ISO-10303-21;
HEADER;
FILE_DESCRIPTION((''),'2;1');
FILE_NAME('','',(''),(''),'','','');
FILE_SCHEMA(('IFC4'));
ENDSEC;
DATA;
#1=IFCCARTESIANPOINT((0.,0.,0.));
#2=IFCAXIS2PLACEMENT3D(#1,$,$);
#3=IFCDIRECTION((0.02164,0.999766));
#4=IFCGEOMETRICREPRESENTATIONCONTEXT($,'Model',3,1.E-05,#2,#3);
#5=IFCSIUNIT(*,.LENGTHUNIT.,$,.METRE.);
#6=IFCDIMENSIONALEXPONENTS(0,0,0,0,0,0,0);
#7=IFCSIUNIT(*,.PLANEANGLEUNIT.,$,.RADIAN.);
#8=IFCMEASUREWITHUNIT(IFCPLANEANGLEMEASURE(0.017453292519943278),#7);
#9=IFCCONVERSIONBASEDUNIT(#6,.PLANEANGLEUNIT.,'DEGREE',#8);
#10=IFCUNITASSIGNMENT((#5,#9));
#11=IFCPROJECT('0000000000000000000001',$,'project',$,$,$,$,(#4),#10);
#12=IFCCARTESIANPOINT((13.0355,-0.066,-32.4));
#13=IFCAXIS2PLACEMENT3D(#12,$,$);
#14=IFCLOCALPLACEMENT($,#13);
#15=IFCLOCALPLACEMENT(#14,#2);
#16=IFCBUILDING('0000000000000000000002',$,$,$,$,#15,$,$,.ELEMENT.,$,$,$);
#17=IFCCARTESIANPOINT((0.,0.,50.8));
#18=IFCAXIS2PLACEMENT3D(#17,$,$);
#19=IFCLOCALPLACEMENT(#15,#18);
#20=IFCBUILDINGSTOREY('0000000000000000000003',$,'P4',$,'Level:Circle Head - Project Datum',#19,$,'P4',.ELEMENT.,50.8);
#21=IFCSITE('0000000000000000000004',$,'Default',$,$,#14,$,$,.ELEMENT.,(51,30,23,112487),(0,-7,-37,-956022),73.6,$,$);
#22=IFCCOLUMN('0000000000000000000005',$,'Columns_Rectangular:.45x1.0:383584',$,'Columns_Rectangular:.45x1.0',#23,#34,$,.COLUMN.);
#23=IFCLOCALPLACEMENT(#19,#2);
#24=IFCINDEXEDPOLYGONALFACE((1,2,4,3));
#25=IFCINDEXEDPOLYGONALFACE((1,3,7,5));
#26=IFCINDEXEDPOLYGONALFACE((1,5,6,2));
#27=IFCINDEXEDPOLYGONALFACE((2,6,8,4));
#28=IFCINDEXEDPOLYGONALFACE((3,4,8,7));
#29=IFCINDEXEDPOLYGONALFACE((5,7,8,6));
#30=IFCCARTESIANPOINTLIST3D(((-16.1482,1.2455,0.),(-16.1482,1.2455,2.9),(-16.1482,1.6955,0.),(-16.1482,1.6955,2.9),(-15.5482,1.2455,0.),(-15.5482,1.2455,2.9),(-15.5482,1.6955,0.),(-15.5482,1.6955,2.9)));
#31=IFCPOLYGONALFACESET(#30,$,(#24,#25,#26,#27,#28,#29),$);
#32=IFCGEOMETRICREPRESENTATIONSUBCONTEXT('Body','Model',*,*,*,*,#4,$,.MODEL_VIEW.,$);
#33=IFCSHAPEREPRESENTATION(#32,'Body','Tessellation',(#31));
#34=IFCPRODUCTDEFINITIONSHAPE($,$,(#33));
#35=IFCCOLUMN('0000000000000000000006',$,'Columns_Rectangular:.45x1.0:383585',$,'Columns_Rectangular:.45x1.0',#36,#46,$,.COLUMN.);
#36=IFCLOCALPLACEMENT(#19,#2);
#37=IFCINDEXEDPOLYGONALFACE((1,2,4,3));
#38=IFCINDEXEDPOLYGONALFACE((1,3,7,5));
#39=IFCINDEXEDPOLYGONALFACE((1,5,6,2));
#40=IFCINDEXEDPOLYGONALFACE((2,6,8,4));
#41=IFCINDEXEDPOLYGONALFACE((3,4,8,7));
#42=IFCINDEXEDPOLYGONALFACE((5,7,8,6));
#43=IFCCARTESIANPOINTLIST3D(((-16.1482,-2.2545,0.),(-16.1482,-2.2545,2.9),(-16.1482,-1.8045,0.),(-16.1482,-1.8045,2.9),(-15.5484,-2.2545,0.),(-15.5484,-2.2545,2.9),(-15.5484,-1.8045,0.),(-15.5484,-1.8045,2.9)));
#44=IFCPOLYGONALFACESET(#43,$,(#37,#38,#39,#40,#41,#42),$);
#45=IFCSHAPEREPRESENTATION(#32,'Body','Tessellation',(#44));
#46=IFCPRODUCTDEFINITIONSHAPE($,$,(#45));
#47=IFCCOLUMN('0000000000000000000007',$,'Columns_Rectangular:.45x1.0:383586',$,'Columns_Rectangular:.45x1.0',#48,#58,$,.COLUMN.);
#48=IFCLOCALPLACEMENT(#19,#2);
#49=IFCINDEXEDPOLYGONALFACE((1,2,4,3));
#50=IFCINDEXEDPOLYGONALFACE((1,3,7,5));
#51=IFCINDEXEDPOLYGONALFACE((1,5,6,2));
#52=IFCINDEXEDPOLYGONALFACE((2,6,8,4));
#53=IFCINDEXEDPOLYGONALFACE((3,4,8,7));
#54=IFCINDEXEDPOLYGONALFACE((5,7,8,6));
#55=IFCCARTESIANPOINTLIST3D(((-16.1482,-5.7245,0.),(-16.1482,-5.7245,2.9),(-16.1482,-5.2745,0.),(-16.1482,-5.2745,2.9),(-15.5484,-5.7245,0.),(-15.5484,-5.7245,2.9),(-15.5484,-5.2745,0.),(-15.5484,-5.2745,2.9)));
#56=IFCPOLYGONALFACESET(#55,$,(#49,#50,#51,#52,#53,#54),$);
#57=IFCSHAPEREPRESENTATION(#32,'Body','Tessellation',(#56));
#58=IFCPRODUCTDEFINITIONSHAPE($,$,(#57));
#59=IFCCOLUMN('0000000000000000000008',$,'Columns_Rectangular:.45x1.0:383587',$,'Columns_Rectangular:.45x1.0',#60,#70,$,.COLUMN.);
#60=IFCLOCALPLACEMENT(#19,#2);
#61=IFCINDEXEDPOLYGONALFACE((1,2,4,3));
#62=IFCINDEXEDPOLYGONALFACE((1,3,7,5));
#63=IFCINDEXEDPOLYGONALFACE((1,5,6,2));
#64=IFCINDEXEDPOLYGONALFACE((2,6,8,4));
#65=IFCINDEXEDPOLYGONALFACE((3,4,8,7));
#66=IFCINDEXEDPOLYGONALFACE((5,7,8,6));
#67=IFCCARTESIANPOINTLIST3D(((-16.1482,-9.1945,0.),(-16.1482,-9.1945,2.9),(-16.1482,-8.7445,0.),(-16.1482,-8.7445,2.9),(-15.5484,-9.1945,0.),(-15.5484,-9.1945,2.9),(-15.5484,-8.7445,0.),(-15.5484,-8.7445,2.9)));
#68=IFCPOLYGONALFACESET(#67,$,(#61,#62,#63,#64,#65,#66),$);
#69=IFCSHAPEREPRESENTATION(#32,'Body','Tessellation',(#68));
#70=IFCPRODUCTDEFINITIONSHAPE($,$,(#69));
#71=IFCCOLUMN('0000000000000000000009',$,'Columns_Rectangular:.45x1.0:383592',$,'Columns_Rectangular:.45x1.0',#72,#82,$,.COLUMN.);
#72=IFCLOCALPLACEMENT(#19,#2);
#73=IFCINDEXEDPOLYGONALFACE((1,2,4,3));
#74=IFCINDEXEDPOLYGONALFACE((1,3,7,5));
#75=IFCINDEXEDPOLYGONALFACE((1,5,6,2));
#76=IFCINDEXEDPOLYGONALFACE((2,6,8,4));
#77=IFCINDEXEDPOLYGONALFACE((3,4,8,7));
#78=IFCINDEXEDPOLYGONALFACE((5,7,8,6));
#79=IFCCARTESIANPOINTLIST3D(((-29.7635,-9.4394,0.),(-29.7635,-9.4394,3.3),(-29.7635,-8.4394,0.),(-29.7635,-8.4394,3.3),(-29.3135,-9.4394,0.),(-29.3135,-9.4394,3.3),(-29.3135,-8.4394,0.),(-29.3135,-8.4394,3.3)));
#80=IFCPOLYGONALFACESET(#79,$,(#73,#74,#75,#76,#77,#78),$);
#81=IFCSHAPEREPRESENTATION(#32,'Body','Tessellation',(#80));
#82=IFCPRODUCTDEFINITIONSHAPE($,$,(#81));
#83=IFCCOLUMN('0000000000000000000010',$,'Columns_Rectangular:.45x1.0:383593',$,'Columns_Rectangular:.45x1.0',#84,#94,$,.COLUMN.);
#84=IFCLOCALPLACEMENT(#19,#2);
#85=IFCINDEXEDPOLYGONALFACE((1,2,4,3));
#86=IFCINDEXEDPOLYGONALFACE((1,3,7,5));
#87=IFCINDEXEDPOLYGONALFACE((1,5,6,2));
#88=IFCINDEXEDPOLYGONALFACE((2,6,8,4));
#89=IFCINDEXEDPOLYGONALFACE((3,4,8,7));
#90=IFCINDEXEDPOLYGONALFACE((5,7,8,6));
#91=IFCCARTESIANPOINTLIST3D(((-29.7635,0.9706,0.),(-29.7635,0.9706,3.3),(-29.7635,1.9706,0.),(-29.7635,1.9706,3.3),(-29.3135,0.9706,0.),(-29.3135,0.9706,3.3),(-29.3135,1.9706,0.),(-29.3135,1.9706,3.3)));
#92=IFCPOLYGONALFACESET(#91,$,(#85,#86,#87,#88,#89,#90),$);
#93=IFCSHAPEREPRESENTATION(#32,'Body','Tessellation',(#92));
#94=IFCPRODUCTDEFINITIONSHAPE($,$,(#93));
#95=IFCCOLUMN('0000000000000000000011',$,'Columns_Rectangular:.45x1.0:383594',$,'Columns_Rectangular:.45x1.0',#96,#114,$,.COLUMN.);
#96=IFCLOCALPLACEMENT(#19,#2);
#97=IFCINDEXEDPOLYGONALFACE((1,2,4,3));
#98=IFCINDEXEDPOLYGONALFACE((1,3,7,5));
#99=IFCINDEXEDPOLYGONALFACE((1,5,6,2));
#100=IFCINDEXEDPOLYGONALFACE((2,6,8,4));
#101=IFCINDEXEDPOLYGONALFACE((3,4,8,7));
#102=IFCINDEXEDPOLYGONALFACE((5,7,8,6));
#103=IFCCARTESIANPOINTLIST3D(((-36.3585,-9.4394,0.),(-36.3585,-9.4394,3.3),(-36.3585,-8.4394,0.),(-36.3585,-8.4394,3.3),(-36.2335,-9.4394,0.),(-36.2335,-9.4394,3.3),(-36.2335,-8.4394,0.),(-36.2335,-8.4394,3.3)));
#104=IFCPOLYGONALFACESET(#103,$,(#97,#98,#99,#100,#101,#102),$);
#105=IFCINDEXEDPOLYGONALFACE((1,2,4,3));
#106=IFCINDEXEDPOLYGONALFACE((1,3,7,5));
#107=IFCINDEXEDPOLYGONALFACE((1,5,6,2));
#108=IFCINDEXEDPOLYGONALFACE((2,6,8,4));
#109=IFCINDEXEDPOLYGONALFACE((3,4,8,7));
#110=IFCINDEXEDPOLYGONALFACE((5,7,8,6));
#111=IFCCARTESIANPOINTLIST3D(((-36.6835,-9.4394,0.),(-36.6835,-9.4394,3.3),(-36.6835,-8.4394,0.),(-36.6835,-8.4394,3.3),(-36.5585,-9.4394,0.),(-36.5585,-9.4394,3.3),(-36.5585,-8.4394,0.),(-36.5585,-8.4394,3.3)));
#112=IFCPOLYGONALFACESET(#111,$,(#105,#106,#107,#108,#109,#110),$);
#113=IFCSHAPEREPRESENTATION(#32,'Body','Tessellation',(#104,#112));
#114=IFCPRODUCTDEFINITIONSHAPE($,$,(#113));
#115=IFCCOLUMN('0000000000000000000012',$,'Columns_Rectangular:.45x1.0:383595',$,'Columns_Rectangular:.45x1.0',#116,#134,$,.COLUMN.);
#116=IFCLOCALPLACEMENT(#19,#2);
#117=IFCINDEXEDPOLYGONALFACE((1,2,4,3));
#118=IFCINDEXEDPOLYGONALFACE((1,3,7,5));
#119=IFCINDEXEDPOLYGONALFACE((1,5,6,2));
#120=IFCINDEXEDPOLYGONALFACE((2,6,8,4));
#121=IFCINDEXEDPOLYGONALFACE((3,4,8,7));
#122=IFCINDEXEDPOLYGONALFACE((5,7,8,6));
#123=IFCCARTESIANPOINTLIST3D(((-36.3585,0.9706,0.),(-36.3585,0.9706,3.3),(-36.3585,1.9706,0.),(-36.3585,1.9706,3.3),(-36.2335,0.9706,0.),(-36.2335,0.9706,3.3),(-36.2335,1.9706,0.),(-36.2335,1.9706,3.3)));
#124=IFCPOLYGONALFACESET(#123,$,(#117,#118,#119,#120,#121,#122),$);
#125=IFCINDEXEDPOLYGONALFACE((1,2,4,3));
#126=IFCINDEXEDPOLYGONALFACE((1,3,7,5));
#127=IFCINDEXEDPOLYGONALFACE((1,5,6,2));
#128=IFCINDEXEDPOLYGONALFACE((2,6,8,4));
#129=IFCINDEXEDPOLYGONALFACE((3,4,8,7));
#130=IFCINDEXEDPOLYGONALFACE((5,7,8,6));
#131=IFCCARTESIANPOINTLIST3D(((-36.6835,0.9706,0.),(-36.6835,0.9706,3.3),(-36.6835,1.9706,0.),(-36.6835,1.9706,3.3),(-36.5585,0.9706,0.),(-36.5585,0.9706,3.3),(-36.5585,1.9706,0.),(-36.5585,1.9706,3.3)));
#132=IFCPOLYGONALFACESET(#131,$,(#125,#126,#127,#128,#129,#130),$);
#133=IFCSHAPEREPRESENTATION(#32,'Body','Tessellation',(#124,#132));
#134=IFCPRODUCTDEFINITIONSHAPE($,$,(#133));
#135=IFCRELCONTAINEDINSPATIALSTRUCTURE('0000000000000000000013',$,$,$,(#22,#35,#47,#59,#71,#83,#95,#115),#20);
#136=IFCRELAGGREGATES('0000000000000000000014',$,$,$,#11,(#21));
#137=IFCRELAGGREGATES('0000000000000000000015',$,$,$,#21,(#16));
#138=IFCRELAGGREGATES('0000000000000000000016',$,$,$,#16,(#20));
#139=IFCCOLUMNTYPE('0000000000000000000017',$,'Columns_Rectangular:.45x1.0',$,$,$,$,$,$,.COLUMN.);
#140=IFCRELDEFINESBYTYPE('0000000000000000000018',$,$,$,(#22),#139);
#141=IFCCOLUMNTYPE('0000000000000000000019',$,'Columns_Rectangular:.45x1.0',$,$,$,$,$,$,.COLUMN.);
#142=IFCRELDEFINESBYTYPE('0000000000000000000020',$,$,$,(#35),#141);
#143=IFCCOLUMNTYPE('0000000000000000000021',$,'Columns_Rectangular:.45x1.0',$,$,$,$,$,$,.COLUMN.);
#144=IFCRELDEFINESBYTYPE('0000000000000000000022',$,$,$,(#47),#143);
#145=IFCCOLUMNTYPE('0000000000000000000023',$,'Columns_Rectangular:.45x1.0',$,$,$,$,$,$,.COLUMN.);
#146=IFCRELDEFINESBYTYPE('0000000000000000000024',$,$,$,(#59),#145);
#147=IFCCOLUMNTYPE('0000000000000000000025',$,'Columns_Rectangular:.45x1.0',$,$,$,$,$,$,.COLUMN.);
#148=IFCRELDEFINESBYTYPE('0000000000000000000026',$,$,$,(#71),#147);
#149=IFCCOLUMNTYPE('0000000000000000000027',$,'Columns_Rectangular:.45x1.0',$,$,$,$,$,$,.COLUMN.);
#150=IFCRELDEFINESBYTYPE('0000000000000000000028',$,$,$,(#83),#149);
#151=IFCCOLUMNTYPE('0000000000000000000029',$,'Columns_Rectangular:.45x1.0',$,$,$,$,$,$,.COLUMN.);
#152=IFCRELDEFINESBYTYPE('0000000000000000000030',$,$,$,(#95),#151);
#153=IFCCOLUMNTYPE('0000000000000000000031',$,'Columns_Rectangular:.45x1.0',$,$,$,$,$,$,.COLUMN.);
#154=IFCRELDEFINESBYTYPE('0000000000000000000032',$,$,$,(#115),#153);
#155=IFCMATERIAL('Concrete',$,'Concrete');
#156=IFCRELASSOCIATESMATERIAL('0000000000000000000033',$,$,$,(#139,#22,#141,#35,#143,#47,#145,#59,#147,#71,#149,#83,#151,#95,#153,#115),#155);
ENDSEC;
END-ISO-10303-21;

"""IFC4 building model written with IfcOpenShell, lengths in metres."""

from ifc_helpers import new_model, entity, si_unit, converted_unit, direction, frame, origin, place, context, subcontext, project, spatial, indexed_curve, outline, extrude, source, transform, mapped, material, type_object, type_shapes, element, save


model = new_model("IFC4")

# Units and contexts
model_context = context("Model", 3, precision=1e-05, world=origin(), true_north=direction((0.02164, 0.999766)))
body_context = subcontext(model_context, "Body", "Model", "MODEL_VIEW")
ifc_project = project(units=[si_unit("LENGTHUNIT", "METRE"), converted_unit("PLANEANGLEUNIT", "DEGREE", entity("IfcPlaneAngleMeasure", 0.017453292519943278), si_unit("PLANEANGLEUNIT", "RADIAN"), dimensions=[0, 0, 0, 0, 0, 0, 0])], contexts=[model_context])

# Site, building, storey
site_placement = place(None, frame((13.0355, -0.066, -32.4)))
site = spatial("IfcSite", under=ifc_project, at=site_placement, Name="Default", CompositionType="ELEMENT", RefLatitude=(51, 30, 23, 112487), RefLongitude=(0, -7, -37, -956022), RefElevation=73.6)
building_placement = place(site_placement, origin())
building = spatial("IfcBuilding", under=site, at=building_placement, CompositionType="ELEMENT")
storey_placement = place(building_placement, frame((0.0, 0.0, 50.8)))
storey = spatial("IfcBuildingStorey", under=building, at=storey_placement, Name="P4", ObjectType="Level:Circle Head - Project Datum", LongName="P4", CompositionType="ELEMENT", Elevation=50.8)

# Columns
ifc_material = material(Name="Concrete", Category="Concrete")
column_type_1 = type_object("IfcColumnType", Name="Columns_Rectangular:.45x1.0", PredefinedType="COLUMN", material=ifc_material)
shared_shape_1 = source(origin(), body_context, "Body", "SweptSolid", [
    extrude(outline(indexed_curve([(-0.3, -0.225), (0.3, -0.225), (0.3, 0.225), (-0.3, 0.225), (-0.3, -0.225)], self_intersect=False)), frame((-15.8482, 1.4705, 50.8), z_axis=(0.0, 0.0, 1.0), x_axis=(-1.0, 0.0, 0.0)), (0.0, 0.0, 1.0), 2.9),
])
type_shapes(column_type_1, [shared_shape_1])
column_1_placement = place(storey_placement, frame((0.0, 0.0, -50.8)))
element("IfcColumn", 1, at=column_1_placement, inside=storey, type_object=column_type_1, material=ifc_material, Name="Columns_Rectangular:.45x1.0:383584", ObjectType="Columns_Rectangular:.45x1.0", PredefinedType="COLUMN", context=body_context, shape_type="MappedRepresentation", body=[
    mapped(shared_shape_1, transform((0.0, 0.0, 0.0), scale=1.0)),
])
column_type_2 = type_object("IfcColumnType", Name="Columns_Rectangular:.45x1.0", PredefinedType="COLUMN", material=ifc_material)
shared_shape_2 = source(origin(), body_context, "Body", "SweptSolid", [
    extrude(outline(indexed_curve([(-0.2999, -0.225), (0.2999, -0.225), (0.2999, 0.225), (-0.2999, 0.225), (-0.2999, -0.225)], self_intersect=False)), frame((-15.8483, -2.0295, 50.8), z_axis=(0.0, 0.0, 1.0), x_axis=(-1.0, 0.0, 0.0)), (0.0, 0.0, 1.0), 2.9),
])
type_shapes(column_type_2, [shared_shape_2])
column_2_placement = place(storey_placement, frame((0.0, 0.0, -50.8)))
element("IfcColumn", 2, at=column_2_placement, inside=storey, type_object=column_type_2, material=ifc_material, Name="Columns_Rectangular:.45x1.0:383585", ObjectType="Columns_Rectangular:.45x1.0", PredefinedType="COLUMN", context=body_context, shape_type="MappedRepresentation", body=[
    mapped(shared_shape_2, transform((0.0, 0.0, 0.0), scale=1.0)),
])
column_type_3 = type_object("IfcColumnType", Name="Columns_Rectangular:.45x1.0", PredefinedType="COLUMN", material=ifc_material)
shared_shape_3 = source(origin(), body_context, "Body", "SweptSolid", [
    extrude(outline(indexed_curve([(-0.2999, -0.225), (0.2999, -0.225), (0.2999, 0.225), (-0.2999, 0.225), (-0.2999, -0.225)], self_intersect=False)), frame((-15.8483, -5.4995, 50.8), z_axis=(0.0, 0.0, 1.0), x_axis=(-1.0, 0.0, 0.0)), (0.0, 0.0, 1.0), 2.9),
])
type_shapes(column_type_3, [shared_shape_3])
column_3_placement = place(storey_placement, frame((0.0, 0.0, -50.8)))
element("IfcColumn", 3, at=column_3_placement, inside=storey, type_object=column_type_3, material=ifc_material, Name="Columns_Rectangular:.45x1.0:383586", ObjectType="Columns_Rectangular:.45x1.0", PredefinedType="COLUMN", context=body_context, shape_type="MappedRepresentation", body=[
    mapped(shared_shape_3, transform((0.0, 0.0, 0.0), scale=1.0)),
])
column_type_4 = type_object("IfcColumnType", Name="Columns_Rectangular:.45x1.0", PredefinedType="COLUMN", material=ifc_material)
shared_shape_4 = source(origin(), body_context, "Body", "SweptSolid", [
    extrude(outline(indexed_curve([(-0.2999, -0.225), (0.2999, -0.225), (0.2999, 0.225), (-0.2999, 0.225), (-0.2999, -0.225)], self_intersect=False)), frame((-15.8483, -8.9695, 50.8), z_axis=(0.0, 0.0, 1.0), x_axis=(-1.0, 0.0, 0.0)), (0.0, 0.0, 1.0), 2.9),
])
type_shapes(column_type_4, [shared_shape_4])
column_4_placement = place(storey_placement, frame((0.0, 0.0, -50.8)))
element("IfcColumn", 4, at=column_4_placement, inside=storey, type_object=column_type_4, material=ifc_material, Name="Columns_Rectangular:.45x1.0:383587", ObjectType="Columns_Rectangular:.45x1.0", PredefinedType="COLUMN", context=body_context, shape_type="MappedRepresentation", body=[
    mapped(shared_shape_4, transform((0.0, 0.0, 0.0), scale=1.0)),
])
column_type_5 = type_object("IfcColumnType", Name="Columns_Rectangular:.45x1.0", PredefinedType="COLUMN", material=ifc_material)
shared_shape_5 = source(origin(), body_context, "Body", "SweptSolid", [
    extrude(outline(indexed_curve([(-0.5, -0.225), (0.5, -0.225), (0.5, 0.225), (-0.5, 0.225), (-0.5, -0.225)], self_intersect=False)), frame((-29.5385, -8.9394, 50.8), z_axis=(0.0, 0.0, 1.0), x_axis=(0.0, 1.0, 0.0)), (0.0, 0.0, 1.0), 3.3),
])
type_shapes(column_type_5, [shared_shape_5])
column_5_placement = place(storey_placement, frame((0.0, 0.0, -50.8)))
element("IfcColumn", 5, at=column_5_placement, inside=storey, type_object=column_type_5, material=ifc_material, Name="Columns_Rectangular:.45x1.0:383592", ObjectType="Columns_Rectangular:.45x1.0", PredefinedType="COLUMN", context=body_context, shape_type="MappedRepresentation", body=[
    mapped(shared_shape_5, transform((0.0, 0.0, 0.0), scale=1.0)),
])
column_type_6 = type_object("IfcColumnType", Name="Columns_Rectangular:.45x1.0", PredefinedType="COLUMN", material=ifc_material)
shared_shape_6 = source(origin(), body_context, "Body", "SweptSolid", [
    extrude(outline(indexed_curve([(-0.5, -0.225), (0.5, -0.225), (0.5, 0.225), (-0.5, 0.225), (-0.5, -0.225)], self_intersect=False)), frame((-29.5385, 1.4706, 50.8), z_axis=(0.0, 0.0, 1.0), x_axis=(0.0, 1.0, 0.0)), (0.0, 0.0, 1.0), 3.3),
])
type_shapes(column_type_6, [shared_shape_6])
column_6_placement = place(storey_placement, frame((0.0, 0.0, -50.8)))
element("IfcColumn", 6, at=column_6_placement, inside=storey, type_object=column_type_6, material=ifc_material, Name="Columns_Rectangular:.45x1.0:383593", ObjectType="Columns_Rectangular:.45x1.0", PredefinedType="COLUMN", context=body_context, shape_type="MappedRepresentation", body=[
    mapped(shared_shape_6, transform((0.0, 0.0, 0.0), scale=1.0)),
])
column_type_7 = type_object("IfcColumnType", Name="Columns_Rectangular:.45x1.0", PredefinedType="COLUMN", material=ifc_material)
shared_shape_7 = source(origin(), body_context, "Body", "SweptSolid", [
    extrude(outline(indexed_curve([(-0.0625, -0.5), (0.0625, -0.5), (0.0625, 0.5), (-0.0625, 0.5), (-0.0625, -0.5)], self_intersect=False)), frame((-36.296, -8.9394, 50.8), z_axis=(0.0, 0.0, 1.0), x_axis=(-1.0, 0.0, 0.0)), (0.0, 0.0, 1.0), 3.3),
    extrude(outline(indexed_curve([(-0.0625, -0.5), (0.0625, -0.5), (0.0625, 0.5), (-0.0625, 0.5), (-0.0625, -0.5)], self_intersect=False)), frame((-36.621, -8.9394, 50.8)), (0.0, 0.0, 1.0), 3.3),
])
type_shapes(column_type_7, [shared_shape_7])
column_7_placement = place(storey_placement, frame((0.0, 0.0, -50.8)))
element("IfcColumn", 7, at=column_7_placement, inside=storey, type_object=column_type_7, material=ifc_material, Name="Columns_Rectangular:.45x1.0:383594", ObjectType="Columns_Rectangular:.45x1.0", PredefinedType="COLUMN", context=body_context, shape_type="MappedRepresentation", body=[
    mapped(shared_shape_7, transform((0.0, 0.0, 0.0), scale=1.0)),
])
column_type_8 = type_object("IfcColumnType", Name="Columns_Rectangular:.45x1.0", PredefinedType="COLUMN", material=ifc_material)
shared_shape_8 = source(origin(), body_context, "Body", "SweptSolid", [
    extrude(outline(indexed_curve([(-0.0625, -0.5), (0.0625, -0.5), (0.0625, 0.5), (-0.0625, 0.5), (-0.0625, -0.5)], self_intersect=False)), frame((-36.296, 1.4706, 50.8), z_axis=(0.0, 0.0, 1.0), x_axis=(-1.0, 0.0, 0.0)), (0.0, 0.0, 1.0), 3.3),
    extrude(outline(indexed_curve([(-0.0625, -0.5), (0.0625, -0.5), (0.0625, 0.5), (-0.0625, 0.5), (-0.0625, -0.5)], self_intersect=False)), frame((-36.621, 1.4706, 50.8)), (0.0, 0.0, 1.0), 3.3),
])
type_shapes(column_type_8, [shared_shape_8])
column_8_placement = place(storey_placement, frame((0.0, 0.0, -50.8)))
element("IfcColumn", 8, at=column_8_placement, inside=storey, type_object=column_type_8, material=ifc_material, Name="Columns_Rectangular:.45x1.0:383595", ObjectType="Columns_Rectangular:.45x1.0", PredefinedType="COLUMN", context=body_context, shape_type="MappedRepresentation", body=[
    mapped(shared_shape_8, transform((0.0, 0.0, 0.0), scale=1.0)),
])

save(model, "model.ifc")
